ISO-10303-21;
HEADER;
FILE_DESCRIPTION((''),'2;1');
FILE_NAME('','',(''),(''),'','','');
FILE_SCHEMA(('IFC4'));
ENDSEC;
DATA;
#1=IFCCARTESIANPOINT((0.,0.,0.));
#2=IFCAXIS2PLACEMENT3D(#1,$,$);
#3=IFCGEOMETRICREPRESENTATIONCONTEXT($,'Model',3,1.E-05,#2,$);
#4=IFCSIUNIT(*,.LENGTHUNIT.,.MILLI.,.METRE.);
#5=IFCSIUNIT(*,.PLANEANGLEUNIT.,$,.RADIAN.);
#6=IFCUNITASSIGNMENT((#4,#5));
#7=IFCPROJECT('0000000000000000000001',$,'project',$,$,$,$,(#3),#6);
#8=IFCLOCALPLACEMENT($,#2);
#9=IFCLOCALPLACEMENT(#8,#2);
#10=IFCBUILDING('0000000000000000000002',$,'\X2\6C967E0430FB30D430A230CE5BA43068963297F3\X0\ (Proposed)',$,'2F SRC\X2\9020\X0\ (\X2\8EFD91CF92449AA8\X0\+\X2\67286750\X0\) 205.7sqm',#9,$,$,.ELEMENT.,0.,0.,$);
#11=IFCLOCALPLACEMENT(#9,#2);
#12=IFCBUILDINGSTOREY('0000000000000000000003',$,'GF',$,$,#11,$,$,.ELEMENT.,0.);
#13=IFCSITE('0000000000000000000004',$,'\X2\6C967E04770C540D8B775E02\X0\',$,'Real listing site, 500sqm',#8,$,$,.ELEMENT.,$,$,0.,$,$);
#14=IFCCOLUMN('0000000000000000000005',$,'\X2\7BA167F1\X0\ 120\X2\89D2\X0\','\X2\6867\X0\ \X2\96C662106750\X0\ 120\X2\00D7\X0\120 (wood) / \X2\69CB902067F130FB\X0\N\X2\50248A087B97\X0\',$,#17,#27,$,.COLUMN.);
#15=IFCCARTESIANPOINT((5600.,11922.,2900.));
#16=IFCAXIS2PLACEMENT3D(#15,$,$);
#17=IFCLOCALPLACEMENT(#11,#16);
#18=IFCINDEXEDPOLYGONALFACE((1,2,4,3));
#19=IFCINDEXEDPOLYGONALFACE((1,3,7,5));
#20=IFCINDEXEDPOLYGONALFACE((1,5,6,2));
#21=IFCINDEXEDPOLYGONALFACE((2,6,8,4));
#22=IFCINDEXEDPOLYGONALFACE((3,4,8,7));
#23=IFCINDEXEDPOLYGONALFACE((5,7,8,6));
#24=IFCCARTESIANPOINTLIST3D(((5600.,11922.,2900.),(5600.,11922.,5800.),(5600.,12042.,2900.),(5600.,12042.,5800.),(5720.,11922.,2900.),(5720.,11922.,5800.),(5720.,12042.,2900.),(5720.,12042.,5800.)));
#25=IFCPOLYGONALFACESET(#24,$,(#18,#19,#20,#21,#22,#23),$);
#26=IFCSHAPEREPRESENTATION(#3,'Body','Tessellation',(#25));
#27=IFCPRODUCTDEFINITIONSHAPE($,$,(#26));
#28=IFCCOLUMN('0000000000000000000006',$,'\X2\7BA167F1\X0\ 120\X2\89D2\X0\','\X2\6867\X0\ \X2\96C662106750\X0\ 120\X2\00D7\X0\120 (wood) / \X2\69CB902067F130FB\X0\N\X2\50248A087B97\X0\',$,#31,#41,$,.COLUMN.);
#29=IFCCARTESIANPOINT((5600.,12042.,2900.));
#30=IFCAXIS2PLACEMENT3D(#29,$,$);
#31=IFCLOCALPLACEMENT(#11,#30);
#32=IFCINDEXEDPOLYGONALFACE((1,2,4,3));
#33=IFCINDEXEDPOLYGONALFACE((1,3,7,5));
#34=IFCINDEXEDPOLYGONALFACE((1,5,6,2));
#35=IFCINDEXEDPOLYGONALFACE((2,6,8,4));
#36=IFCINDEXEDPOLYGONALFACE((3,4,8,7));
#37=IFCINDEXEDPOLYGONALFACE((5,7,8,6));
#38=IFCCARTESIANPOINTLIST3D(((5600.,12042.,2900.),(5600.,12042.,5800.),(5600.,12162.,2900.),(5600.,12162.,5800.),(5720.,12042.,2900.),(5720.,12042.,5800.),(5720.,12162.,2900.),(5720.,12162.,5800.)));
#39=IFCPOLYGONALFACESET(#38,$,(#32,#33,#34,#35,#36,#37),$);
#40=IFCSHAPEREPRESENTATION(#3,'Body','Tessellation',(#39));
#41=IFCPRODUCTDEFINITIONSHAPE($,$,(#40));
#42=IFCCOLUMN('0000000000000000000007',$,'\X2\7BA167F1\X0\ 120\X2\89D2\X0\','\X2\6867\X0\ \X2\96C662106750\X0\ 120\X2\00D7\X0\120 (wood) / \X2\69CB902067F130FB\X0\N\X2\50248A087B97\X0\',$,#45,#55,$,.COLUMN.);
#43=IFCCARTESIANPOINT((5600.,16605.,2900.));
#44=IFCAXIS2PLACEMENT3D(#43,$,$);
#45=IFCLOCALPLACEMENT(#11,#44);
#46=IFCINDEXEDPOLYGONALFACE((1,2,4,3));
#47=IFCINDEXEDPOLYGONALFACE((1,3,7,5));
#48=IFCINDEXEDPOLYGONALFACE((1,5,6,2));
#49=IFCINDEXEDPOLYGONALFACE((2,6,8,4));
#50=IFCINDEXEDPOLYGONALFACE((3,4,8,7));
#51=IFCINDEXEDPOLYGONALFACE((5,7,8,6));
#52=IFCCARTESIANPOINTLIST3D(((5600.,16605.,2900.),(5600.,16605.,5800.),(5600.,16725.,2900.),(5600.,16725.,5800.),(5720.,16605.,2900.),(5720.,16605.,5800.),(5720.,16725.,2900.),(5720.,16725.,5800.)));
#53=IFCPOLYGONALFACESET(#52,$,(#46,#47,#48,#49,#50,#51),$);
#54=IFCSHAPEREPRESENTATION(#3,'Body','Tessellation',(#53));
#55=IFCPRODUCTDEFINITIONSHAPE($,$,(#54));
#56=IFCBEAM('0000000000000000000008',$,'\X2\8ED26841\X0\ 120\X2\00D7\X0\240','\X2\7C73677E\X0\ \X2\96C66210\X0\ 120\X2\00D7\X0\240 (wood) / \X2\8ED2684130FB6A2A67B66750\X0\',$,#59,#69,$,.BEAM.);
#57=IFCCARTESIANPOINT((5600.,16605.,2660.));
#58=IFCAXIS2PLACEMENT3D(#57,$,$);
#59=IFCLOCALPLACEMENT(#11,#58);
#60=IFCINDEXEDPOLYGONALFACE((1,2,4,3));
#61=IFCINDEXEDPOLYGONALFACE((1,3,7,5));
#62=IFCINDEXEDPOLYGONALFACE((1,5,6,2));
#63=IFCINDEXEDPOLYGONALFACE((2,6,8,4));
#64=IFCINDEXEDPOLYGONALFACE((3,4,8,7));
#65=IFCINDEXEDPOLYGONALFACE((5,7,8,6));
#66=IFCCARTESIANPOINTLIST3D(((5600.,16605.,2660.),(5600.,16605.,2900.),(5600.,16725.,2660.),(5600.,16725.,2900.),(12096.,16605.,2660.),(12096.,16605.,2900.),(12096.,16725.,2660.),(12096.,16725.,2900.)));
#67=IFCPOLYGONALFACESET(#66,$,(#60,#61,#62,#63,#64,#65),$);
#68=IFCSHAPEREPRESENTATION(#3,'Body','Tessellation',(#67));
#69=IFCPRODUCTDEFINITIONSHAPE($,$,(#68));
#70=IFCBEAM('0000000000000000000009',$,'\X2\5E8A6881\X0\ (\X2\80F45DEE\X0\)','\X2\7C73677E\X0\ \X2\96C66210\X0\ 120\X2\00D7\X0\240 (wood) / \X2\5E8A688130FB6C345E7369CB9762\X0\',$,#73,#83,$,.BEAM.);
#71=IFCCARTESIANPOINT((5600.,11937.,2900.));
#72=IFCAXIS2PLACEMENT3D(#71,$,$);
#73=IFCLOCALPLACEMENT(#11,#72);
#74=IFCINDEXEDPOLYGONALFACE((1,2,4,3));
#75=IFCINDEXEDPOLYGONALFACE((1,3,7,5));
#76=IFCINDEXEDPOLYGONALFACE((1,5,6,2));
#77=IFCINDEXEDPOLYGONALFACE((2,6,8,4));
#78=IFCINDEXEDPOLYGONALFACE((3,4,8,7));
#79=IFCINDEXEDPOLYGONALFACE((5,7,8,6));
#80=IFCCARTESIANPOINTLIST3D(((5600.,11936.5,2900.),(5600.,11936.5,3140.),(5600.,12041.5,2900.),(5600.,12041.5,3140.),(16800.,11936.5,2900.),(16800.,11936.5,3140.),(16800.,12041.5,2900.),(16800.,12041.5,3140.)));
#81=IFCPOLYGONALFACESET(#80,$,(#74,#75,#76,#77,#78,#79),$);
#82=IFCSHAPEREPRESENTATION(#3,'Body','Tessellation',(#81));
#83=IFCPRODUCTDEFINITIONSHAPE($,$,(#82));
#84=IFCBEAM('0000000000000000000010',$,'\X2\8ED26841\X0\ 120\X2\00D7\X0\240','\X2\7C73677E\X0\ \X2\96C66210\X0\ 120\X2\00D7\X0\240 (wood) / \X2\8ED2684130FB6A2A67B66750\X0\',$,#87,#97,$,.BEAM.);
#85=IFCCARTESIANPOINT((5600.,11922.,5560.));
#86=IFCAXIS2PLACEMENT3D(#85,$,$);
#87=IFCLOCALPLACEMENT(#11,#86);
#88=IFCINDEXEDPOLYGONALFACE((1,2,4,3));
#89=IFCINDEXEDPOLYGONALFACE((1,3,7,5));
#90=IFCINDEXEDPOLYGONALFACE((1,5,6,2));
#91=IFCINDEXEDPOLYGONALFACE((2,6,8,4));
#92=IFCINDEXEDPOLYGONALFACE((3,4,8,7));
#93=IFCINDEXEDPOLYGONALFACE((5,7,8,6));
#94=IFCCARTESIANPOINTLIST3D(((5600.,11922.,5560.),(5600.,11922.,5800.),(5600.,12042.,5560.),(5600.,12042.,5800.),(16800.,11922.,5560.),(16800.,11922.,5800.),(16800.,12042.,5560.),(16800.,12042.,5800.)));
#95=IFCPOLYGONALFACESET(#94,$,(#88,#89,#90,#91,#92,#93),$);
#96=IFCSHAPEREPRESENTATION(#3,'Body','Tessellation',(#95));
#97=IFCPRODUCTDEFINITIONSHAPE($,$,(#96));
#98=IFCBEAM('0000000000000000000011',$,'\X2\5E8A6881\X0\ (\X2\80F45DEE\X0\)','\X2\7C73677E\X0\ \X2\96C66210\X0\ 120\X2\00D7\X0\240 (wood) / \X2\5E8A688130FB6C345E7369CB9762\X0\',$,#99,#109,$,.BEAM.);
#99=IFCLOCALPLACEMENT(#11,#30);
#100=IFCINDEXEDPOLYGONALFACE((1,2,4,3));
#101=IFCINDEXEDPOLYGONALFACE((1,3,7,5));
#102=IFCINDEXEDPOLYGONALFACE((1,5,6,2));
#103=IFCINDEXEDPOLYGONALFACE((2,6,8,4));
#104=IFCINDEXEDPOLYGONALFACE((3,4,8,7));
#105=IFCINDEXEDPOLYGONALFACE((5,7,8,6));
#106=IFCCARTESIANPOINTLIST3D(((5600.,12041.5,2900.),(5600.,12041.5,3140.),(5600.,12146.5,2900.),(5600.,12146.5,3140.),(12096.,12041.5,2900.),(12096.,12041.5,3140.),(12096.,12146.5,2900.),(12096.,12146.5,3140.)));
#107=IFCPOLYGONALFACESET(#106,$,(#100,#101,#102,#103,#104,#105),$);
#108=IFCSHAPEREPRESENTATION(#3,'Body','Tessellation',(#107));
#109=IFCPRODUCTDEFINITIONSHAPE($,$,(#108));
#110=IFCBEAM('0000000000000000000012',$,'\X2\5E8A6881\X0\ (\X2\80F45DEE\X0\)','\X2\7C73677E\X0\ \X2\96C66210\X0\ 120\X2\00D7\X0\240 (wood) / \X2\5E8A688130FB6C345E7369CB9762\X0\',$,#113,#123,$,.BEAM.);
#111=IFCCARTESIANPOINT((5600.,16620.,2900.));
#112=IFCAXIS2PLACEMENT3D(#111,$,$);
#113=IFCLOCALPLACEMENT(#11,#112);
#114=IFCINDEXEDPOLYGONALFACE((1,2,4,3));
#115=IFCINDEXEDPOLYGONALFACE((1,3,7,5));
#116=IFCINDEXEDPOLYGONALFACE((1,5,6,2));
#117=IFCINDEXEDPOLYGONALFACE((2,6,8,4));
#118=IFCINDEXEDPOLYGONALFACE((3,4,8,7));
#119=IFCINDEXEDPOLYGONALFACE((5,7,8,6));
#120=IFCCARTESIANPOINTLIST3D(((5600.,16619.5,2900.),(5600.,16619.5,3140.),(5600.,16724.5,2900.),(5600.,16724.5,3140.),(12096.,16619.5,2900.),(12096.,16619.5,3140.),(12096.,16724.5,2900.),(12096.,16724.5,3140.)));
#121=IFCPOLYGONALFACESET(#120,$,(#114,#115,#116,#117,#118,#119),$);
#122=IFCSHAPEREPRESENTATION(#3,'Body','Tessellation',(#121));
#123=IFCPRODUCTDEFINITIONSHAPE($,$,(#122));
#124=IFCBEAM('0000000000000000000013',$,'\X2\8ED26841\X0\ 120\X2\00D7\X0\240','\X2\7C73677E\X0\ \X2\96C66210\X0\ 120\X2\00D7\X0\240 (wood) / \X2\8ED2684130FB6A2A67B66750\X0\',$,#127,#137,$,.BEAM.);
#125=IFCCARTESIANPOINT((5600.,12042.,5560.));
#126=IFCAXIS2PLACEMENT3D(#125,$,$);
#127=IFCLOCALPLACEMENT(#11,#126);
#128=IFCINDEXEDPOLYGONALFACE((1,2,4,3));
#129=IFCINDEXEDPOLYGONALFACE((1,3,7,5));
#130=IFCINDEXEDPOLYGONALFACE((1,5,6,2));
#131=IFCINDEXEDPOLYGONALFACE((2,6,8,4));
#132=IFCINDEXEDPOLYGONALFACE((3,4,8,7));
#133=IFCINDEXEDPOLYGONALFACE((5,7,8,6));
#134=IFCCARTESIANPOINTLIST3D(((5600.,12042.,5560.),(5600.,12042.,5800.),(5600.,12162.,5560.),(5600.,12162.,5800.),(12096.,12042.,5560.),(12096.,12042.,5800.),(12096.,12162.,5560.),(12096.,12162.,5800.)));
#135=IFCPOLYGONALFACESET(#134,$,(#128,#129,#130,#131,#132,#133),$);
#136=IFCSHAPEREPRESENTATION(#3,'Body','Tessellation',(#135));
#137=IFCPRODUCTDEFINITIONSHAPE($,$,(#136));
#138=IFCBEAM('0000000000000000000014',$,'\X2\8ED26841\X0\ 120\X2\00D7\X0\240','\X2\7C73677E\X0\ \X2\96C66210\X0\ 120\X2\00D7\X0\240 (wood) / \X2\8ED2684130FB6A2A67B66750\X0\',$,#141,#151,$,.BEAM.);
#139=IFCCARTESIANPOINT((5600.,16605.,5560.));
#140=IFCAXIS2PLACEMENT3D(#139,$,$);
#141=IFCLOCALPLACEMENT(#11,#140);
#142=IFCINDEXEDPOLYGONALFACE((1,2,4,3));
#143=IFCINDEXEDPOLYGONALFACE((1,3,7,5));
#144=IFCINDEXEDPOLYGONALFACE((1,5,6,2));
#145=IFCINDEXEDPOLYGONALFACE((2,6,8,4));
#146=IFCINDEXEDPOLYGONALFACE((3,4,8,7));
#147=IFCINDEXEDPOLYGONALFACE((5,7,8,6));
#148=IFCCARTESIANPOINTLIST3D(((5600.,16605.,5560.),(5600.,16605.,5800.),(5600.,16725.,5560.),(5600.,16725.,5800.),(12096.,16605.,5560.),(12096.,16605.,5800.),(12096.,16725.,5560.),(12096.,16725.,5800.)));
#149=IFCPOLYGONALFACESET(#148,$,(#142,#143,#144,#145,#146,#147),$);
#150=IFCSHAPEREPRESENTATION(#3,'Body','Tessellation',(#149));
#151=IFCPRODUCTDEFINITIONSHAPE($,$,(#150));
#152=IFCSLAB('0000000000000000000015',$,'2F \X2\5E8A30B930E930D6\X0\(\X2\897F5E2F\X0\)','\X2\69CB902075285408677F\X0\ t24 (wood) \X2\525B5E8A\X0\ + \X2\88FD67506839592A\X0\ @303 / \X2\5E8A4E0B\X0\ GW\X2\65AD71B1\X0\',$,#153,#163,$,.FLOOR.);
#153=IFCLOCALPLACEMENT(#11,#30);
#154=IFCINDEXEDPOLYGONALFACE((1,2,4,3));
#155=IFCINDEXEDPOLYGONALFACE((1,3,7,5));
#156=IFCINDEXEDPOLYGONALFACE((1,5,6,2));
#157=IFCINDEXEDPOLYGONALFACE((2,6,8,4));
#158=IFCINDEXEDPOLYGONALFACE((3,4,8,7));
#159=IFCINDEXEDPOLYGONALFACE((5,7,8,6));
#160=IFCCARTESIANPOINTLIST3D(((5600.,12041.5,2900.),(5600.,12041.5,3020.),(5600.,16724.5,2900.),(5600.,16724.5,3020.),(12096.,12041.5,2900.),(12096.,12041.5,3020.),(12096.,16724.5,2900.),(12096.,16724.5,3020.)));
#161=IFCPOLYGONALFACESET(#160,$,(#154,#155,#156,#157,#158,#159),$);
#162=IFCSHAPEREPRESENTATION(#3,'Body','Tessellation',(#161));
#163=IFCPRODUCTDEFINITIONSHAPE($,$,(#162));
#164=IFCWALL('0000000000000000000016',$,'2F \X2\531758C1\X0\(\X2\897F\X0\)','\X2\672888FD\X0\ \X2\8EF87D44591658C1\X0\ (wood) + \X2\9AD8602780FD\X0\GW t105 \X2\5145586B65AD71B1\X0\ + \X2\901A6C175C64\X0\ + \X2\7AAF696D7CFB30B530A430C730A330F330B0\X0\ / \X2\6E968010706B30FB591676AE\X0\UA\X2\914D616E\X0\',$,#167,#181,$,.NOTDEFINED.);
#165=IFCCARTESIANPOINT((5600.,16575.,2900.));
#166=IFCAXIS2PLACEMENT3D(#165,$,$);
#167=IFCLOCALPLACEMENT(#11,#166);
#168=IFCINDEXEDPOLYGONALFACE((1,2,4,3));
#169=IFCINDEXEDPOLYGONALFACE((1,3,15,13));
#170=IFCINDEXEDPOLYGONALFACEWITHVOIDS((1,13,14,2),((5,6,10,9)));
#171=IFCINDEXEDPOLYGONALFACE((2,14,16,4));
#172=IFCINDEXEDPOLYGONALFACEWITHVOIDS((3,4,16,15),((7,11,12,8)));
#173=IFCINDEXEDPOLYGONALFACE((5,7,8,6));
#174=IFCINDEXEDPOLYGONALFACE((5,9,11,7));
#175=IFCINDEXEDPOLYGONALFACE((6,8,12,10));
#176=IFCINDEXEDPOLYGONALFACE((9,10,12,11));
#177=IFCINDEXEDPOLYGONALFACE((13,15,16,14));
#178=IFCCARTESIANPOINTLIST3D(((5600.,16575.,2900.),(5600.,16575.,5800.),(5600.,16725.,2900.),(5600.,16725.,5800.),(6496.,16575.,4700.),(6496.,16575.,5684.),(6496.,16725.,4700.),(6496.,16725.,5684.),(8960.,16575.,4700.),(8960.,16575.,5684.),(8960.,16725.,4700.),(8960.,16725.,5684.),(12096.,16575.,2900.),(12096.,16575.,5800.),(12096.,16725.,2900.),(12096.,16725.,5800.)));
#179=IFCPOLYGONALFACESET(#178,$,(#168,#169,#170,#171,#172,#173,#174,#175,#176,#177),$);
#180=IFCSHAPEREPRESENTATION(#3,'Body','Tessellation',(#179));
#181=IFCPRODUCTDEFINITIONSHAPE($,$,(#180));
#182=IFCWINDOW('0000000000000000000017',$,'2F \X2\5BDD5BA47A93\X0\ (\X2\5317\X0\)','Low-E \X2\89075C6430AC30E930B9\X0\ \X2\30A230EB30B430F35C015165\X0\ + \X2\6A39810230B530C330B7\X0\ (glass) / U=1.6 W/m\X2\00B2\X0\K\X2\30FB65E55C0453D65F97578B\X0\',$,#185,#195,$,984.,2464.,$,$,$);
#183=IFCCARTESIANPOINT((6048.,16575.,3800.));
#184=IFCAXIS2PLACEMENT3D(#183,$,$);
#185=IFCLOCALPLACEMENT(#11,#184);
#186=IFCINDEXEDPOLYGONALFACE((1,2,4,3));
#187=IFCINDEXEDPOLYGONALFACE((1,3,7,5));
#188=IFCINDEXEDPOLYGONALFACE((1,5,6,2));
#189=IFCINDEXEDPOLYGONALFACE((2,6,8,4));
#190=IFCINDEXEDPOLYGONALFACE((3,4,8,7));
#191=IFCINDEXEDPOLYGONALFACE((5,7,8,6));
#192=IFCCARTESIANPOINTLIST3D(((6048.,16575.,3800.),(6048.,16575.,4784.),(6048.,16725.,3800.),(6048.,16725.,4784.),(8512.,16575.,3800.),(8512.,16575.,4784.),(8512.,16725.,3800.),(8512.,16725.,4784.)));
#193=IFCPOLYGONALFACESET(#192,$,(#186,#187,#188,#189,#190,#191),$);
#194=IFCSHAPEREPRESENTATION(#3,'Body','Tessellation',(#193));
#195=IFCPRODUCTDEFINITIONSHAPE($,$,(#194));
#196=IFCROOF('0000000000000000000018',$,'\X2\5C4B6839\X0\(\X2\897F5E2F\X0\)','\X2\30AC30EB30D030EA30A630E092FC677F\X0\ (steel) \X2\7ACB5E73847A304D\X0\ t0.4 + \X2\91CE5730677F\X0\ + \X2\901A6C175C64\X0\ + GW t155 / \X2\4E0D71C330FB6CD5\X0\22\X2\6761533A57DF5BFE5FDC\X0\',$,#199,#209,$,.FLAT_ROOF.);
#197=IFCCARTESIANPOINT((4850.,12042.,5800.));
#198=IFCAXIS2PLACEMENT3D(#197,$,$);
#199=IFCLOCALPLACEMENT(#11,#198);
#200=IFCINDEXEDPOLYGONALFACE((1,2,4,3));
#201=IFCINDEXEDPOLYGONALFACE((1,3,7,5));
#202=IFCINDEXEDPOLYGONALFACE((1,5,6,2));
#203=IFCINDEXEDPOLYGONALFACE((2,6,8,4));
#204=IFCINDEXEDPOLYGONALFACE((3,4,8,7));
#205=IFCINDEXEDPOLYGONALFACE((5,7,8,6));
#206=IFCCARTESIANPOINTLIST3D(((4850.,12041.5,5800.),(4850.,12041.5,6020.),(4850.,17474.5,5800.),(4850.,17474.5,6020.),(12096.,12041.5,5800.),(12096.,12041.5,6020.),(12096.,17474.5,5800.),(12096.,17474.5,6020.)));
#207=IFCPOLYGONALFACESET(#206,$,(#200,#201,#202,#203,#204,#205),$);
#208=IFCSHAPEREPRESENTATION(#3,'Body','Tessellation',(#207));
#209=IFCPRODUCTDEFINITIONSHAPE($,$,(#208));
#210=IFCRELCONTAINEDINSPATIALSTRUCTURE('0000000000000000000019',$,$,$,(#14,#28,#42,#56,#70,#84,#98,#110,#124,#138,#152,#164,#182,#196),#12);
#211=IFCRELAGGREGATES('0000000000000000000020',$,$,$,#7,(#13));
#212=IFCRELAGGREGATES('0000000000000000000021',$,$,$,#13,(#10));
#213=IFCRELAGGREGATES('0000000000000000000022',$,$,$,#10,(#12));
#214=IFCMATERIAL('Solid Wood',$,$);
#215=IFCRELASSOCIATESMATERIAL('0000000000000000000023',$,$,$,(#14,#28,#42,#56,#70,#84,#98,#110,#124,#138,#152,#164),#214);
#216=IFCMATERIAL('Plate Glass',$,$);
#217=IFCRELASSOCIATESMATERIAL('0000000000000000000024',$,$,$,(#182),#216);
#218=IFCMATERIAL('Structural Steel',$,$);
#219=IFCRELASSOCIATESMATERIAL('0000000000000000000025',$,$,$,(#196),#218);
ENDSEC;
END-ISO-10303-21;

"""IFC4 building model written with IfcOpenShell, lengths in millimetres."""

from ifc_helpers import new_model, si_unit, frame, frame_2d, origin, place, context, project, spatial, rectangle, extrude, material, element, fill, save


model = new_model("IFC4")

# Units and contexts
model_context = context("Model", 3, precision=1e-05, world=origin())
ifc_project = project(units=[si_unit("LENGTHUNIT", "METRE", prefix="MILLI"), si_unit("PLANEANGLEUNIT", "RADIAN")], contexts=[model_context])

# Site, building, storey
site_placement = place(None, origin())
site = spatial("IfcSite", under=ifc_project, at=site_placement, Name="沖縄県名護市", ObjectType="Real listing site, 500sqm", CompositionType="ELEMENT", RefElevation=0.0)
building_placement = place(site_placement, origin())
building = spatial("IfcBuilding", under=site, at=building_placement, Name="沖縄・ピアノ室と防音 (Proposed)", ObjectType="2F SRC造 (軽量鉄骨+木材) 205.7sqm", CompositionType="ELEMENT", ElevationOfRefHeight=0.0, ElevationOfTerrain=0.0)
storey_placement = place(building_placement, origin())
storey = spatial("IfcBuildingStorey", under=building, at=storey_placement, Name="GF", CompositionType="ELEMENT", Elevation=0.0)

# Columns
ifc_material_1 = material(Name="Solid Wood")
column_1_placement = place(storey_placement, frame((5600.0, 11922.0, 2900.0)))
element("IfcColumn", 1, at=column_1_placement, inside=storey, material=ifc_material_1, Name="管柱 120角", Description="桧 集成材 120×120 (wood) / 構造柱・N値計算", PredefinedType="COLUMN", context=model_context, shape_type="SweptSolid", body=[
    extrude(rectangle(XDim=120.0, YDim=120.0, at=frame_2d((60.0, 60.0))), frame((5600.0, 11922.0, 2900.0)), (0.0, 0.0, 1.0), 2900.0),
])
column_2_placement = place(storey_placement, frame((5600.0, 12042.0, 2900.0)))
element("IfcColumn", 2, at=column_2_placement, inside=storey, material=ifc_material_1, Name="管柱 120角", Description="桧 集成材 120×120 (wood) / 構造柱・N値計算", PredefinedType="COLUMN", context=model_context, shape_type="SweptSolid", body=[
    extrude(rectangle(XDim=120.0, YDim=120.0, at=frame_2d((60.0, 60.0))), frame((5600.0, 12042.0, 2900.0)), (0.0, 0.0, 1.0), 2900.0),
])
column_3_placement = place(storey_placement, frame((5600.0, 16605.0, 2900.0)))
element("IfcColumn", 3, at=column_3_placement, inside=storey, material=ifc_material_1, Name="管柱 120角", Description="桧 集成材 120×120 (wood) / 構造柱・N値計算", PredefinedType="COLUMN", context=model_context, shape_type="SweptSolid", body=[
    extrude(rectangle(XDim=120.0, YDim=120.0, at=frame_2d((60.0, 60.0))), frame((5600.0, 16605.0, 2900.0)), (0.0, 0.0, 1.0), 2900.0),
])

# Beams
beam_1_placement = place(storey_placement, frame((5600.0, 16605.0, 2660.0)))
element("IfcBeam", 4, at=beam_1_placement, inside=storey, material=ifc_material_1, Name="軒桁 120×240", Description="米松 集成 120×240 (wood) / 軒桁・横架材", PredefinedType="BEAM", context=model_context, shape_type="SweptSolid", body=[
    extrude(rectangle(XDim=6496.0, YDim=120.0, at=frame_2d((3248.0, 60.0))), frame((5600.0, 16605.0, 2660.0)), (0.0, 0.0, 1.0), 240.0),
])
beam_2_placement = place(storey_placement, frame((5600.0, 11937.0, 2900.0)))
element("IfcBeam", 5, at=beam_2_placement, inside=storey, material=ifc_material_1, Name="床梁 (胴差)", Description="米松 集成 120×240 (wood) / 床梁・水平構面", PredefinedType="BEAM", context=model_context, shape_type="SweptSolid", body=[
    extrude(rectangle(XDim=11200.0, YDim=105.0, at=frame_2d((5600.0, 52.0))), frame((5600.0, 11937.0, 2900.0)), (0.0, 0.0, 1.0), 240.0),
])
beam_3_placement = place(storey_placement, frame((5600.0, 11922.0, 5560.0)))
element("IfcBeam", 6, at=beam_3_placement, inside=storey, material=ifc_material_1, Name="軒桁 120×240", Description="米松 集成 120×240 (wood) / 軒桁・横架材", PredefinedType="BEAM", context=model_context, shape_type="SweptSolid", body=[
    extrude(rectangle(XDim=11200.0, YDim=120.0, at=frame_2d((5600.0, 60.0))), frame((5600.0, 11922.0, 5560.0)), (0.0, 0.0, 1.0), 240.0),
])
beam_4_placement = place(storey_placement, frame((5600.0, 12042.0, 2900.0)))
element("IfcBeam", 7, at=beam_4_placement, inside=storey, material=ifc_material_1, Name="床梁 (胴差)", Description="米松 集成 120×240 (wood) / 床梁・水平構面", PredefinedType="BEAM", context=model_context, shape_type="SweptSolid", body=[
    extrude(rectangle(XDim=6496.0, YDim=105.0, at=frame_2d((3248.0, 52.0))), frame((5600.0, 12042.0, 2900.0)), (0.0, 0.0, 1.0), 240.0),
])
beam_5_placement = place(storey_placement, frame((5600.0, 16620.0, 2900.0)))
element("IfcBeam", 8, at=beam_5_placement, inside=storey, material=ifc_material_1, Name="床梁 (胴差)", Description="米松 集成 120×240 (wood) / 床梁・水平構面", PredefinedType="BEAM", context=model_context, shape_type="SweptSolid", body=[
    extrude(rectangle(XDim=6496.0, YDim=105.0, at=frame_2d((3248.0, 52.0))), frame((5600.0, 16620.0, 2900.0)), (0.0, 0.0, 1.0), 240.0),
])
beam_6_placement = place(storey_placement, frame((5600.0, 12042.0, 5560.0)))
element("IfcBeam", 9, at=beam_6_placement, inside=storey, material=ifc_material_1, Name="軒桁 120×240", Description="米松 集成 120×240 (wood) / 軒桁・横架材", PredefinedType="BEAM", context=model_context, shape_type="SweptSolid", body=[
    extrude(rectangle(XDim=6496.0, YDim=120.0, at=frame_2d((3248.0, 60.0))), frame((5600.0, 12042.0, 5560.0)), (0.0, 0.0, 1.0), 240.0),
])
beam_7_placement = place(storey_placement, frame((5600.0, 16605.0, 5560.0)))
element("IfcBeam", 10, at=beam_7_placement, inside=storey, material=ifc_material_1, Name="軒桁 120×240", Description="米松 集成 120×240 (wood) / 軒桁・横架材", PredefinedType="BEAM", context=model_context, shape_type="SweptSolid", body=[
    extrude(rectangle(XDim=6496.0, YDim=120.0, at=frame_2d((3248.0, 60.0))), frame((5600.0, 16605.0, 5560.0)), (0.0, 0.0, 1.0), 240.0),
])

# Slab
slab_placement = place(storey_placement, frame((5600.0, 12042.0, 2900.0)))
element("IfcSlab", 11, at=slab_placement, inside=storey, material=ifc_material_1, Name="2F 床スラブ(西帯)", Description="構造用合板 t24 (wood) 剛床 + 製材根太 @303 / 床下 GW断熱", PredefinedType="FLOOR", context=model_context, shape_type="SweptSolid", body=[
    extrude(rectangle(XDim=6496.0, YDim=4683.0, at=frame_2d((3248.0, 2341.0))), frame((5600.0, 12042.0, 2900.0)), (0.0, 0.0, 1.0), 120.0),
])

# Wall, opening, window
wall_1_placement = place(storey_placement, frame((5600.0, 16575.0, 2900.0)))
wall_1 = element("IfcWall", 12, at=wall_1_placement, inside=storey, material=ifc_material_1, Name="2F 北壁(西)", Description="木製 軸組外壁 (wood) + 高性能GW t105 充填断熱 + 通気層 + 窯業系サイディング / 準耐火・外皮UA配慮", PredefinedType="NOTDEFINED", context=model_context, shape_type="SweptSolid", body=[
    extrude(rectangle(XDim=6496.0, YDim=150.0, at=frame_2d((3248.0, 75.0))), frame((5600.0, 16575.0, 2900.0)), (0.0, 0.0, 1.0), 2900.0),
])
opening_placement = place(storey_placement, frame((6048.0, 16575.0, 3800.0)))
opening = element("IfcOpeningElement", 13, at=opening_placement, cuts=wall_1, PredefinedType="NOTDEFINED", context=model_context, shape_type="SweptSolid", body=[
    extrude(rectangle(XDim=2464.0, YDim=150.0, at=frame_2d((1232.0, 75.0))), frame((6048.0, 16575.0, 3800.0)), (0.0, 0.0, 1.0), 984.0),
])
ifc_material_2 = material(Name="Plate Glass")
window_placement = place(storey_placement, frame((6048.0, 16575.0, 3800.0)))
window = element("IfcWindow", 14, at=window_placement, inside=storey, material=ifc_material_2, Name="2F 寝室窓 (北)", Description="Low-E 複層ガラス アルゴン封入 + 樹脂サッシ (glass) / U=1.6 W/m²K・日射取得型", OverallHeight=984.0, OverallWidth=2464.0, context=model_context, shape_type="SweptSolid", body=[
    extrude(rectangle(XDim=2464.0, YDim=150.0, at=frame_2d((1232.0, 75.0))), frame((6048.0, 16575.0, 3800.0)), (0.0, 0.0, 1.0), 984.0),
])
fill(opening, window)

# Roof
ifc_material_3 = material(Name="Structural Steel")
for number, where, name in (
    (15, (4850.0, 12042.0, 5800.0), "屋根(西帯)"),
):
    element("IfcRoof", number, at=place(storey_placement, frame(where)), inside=storey, material=ifc_material_3, Name=name, Description="ガルバリウム鋼板 (steel) 立平葺き t0.4 + 野地板 + 通気層 + GW t155 / 不燃・法22条区域対応", PredefinedType="FLAT_ROOF", context=model_context, shape_type="SweptSolid", body=[
        extrude(rectangle(XDim=7246.0, YDim=5433.0, at=frame_2d((3623.0, 2716.0))), frame((4850.0, 12042.0, 5800.0)), (0.0, 0.0, 1.0), 220.0),
    ])

save(model, "model.ifc")
